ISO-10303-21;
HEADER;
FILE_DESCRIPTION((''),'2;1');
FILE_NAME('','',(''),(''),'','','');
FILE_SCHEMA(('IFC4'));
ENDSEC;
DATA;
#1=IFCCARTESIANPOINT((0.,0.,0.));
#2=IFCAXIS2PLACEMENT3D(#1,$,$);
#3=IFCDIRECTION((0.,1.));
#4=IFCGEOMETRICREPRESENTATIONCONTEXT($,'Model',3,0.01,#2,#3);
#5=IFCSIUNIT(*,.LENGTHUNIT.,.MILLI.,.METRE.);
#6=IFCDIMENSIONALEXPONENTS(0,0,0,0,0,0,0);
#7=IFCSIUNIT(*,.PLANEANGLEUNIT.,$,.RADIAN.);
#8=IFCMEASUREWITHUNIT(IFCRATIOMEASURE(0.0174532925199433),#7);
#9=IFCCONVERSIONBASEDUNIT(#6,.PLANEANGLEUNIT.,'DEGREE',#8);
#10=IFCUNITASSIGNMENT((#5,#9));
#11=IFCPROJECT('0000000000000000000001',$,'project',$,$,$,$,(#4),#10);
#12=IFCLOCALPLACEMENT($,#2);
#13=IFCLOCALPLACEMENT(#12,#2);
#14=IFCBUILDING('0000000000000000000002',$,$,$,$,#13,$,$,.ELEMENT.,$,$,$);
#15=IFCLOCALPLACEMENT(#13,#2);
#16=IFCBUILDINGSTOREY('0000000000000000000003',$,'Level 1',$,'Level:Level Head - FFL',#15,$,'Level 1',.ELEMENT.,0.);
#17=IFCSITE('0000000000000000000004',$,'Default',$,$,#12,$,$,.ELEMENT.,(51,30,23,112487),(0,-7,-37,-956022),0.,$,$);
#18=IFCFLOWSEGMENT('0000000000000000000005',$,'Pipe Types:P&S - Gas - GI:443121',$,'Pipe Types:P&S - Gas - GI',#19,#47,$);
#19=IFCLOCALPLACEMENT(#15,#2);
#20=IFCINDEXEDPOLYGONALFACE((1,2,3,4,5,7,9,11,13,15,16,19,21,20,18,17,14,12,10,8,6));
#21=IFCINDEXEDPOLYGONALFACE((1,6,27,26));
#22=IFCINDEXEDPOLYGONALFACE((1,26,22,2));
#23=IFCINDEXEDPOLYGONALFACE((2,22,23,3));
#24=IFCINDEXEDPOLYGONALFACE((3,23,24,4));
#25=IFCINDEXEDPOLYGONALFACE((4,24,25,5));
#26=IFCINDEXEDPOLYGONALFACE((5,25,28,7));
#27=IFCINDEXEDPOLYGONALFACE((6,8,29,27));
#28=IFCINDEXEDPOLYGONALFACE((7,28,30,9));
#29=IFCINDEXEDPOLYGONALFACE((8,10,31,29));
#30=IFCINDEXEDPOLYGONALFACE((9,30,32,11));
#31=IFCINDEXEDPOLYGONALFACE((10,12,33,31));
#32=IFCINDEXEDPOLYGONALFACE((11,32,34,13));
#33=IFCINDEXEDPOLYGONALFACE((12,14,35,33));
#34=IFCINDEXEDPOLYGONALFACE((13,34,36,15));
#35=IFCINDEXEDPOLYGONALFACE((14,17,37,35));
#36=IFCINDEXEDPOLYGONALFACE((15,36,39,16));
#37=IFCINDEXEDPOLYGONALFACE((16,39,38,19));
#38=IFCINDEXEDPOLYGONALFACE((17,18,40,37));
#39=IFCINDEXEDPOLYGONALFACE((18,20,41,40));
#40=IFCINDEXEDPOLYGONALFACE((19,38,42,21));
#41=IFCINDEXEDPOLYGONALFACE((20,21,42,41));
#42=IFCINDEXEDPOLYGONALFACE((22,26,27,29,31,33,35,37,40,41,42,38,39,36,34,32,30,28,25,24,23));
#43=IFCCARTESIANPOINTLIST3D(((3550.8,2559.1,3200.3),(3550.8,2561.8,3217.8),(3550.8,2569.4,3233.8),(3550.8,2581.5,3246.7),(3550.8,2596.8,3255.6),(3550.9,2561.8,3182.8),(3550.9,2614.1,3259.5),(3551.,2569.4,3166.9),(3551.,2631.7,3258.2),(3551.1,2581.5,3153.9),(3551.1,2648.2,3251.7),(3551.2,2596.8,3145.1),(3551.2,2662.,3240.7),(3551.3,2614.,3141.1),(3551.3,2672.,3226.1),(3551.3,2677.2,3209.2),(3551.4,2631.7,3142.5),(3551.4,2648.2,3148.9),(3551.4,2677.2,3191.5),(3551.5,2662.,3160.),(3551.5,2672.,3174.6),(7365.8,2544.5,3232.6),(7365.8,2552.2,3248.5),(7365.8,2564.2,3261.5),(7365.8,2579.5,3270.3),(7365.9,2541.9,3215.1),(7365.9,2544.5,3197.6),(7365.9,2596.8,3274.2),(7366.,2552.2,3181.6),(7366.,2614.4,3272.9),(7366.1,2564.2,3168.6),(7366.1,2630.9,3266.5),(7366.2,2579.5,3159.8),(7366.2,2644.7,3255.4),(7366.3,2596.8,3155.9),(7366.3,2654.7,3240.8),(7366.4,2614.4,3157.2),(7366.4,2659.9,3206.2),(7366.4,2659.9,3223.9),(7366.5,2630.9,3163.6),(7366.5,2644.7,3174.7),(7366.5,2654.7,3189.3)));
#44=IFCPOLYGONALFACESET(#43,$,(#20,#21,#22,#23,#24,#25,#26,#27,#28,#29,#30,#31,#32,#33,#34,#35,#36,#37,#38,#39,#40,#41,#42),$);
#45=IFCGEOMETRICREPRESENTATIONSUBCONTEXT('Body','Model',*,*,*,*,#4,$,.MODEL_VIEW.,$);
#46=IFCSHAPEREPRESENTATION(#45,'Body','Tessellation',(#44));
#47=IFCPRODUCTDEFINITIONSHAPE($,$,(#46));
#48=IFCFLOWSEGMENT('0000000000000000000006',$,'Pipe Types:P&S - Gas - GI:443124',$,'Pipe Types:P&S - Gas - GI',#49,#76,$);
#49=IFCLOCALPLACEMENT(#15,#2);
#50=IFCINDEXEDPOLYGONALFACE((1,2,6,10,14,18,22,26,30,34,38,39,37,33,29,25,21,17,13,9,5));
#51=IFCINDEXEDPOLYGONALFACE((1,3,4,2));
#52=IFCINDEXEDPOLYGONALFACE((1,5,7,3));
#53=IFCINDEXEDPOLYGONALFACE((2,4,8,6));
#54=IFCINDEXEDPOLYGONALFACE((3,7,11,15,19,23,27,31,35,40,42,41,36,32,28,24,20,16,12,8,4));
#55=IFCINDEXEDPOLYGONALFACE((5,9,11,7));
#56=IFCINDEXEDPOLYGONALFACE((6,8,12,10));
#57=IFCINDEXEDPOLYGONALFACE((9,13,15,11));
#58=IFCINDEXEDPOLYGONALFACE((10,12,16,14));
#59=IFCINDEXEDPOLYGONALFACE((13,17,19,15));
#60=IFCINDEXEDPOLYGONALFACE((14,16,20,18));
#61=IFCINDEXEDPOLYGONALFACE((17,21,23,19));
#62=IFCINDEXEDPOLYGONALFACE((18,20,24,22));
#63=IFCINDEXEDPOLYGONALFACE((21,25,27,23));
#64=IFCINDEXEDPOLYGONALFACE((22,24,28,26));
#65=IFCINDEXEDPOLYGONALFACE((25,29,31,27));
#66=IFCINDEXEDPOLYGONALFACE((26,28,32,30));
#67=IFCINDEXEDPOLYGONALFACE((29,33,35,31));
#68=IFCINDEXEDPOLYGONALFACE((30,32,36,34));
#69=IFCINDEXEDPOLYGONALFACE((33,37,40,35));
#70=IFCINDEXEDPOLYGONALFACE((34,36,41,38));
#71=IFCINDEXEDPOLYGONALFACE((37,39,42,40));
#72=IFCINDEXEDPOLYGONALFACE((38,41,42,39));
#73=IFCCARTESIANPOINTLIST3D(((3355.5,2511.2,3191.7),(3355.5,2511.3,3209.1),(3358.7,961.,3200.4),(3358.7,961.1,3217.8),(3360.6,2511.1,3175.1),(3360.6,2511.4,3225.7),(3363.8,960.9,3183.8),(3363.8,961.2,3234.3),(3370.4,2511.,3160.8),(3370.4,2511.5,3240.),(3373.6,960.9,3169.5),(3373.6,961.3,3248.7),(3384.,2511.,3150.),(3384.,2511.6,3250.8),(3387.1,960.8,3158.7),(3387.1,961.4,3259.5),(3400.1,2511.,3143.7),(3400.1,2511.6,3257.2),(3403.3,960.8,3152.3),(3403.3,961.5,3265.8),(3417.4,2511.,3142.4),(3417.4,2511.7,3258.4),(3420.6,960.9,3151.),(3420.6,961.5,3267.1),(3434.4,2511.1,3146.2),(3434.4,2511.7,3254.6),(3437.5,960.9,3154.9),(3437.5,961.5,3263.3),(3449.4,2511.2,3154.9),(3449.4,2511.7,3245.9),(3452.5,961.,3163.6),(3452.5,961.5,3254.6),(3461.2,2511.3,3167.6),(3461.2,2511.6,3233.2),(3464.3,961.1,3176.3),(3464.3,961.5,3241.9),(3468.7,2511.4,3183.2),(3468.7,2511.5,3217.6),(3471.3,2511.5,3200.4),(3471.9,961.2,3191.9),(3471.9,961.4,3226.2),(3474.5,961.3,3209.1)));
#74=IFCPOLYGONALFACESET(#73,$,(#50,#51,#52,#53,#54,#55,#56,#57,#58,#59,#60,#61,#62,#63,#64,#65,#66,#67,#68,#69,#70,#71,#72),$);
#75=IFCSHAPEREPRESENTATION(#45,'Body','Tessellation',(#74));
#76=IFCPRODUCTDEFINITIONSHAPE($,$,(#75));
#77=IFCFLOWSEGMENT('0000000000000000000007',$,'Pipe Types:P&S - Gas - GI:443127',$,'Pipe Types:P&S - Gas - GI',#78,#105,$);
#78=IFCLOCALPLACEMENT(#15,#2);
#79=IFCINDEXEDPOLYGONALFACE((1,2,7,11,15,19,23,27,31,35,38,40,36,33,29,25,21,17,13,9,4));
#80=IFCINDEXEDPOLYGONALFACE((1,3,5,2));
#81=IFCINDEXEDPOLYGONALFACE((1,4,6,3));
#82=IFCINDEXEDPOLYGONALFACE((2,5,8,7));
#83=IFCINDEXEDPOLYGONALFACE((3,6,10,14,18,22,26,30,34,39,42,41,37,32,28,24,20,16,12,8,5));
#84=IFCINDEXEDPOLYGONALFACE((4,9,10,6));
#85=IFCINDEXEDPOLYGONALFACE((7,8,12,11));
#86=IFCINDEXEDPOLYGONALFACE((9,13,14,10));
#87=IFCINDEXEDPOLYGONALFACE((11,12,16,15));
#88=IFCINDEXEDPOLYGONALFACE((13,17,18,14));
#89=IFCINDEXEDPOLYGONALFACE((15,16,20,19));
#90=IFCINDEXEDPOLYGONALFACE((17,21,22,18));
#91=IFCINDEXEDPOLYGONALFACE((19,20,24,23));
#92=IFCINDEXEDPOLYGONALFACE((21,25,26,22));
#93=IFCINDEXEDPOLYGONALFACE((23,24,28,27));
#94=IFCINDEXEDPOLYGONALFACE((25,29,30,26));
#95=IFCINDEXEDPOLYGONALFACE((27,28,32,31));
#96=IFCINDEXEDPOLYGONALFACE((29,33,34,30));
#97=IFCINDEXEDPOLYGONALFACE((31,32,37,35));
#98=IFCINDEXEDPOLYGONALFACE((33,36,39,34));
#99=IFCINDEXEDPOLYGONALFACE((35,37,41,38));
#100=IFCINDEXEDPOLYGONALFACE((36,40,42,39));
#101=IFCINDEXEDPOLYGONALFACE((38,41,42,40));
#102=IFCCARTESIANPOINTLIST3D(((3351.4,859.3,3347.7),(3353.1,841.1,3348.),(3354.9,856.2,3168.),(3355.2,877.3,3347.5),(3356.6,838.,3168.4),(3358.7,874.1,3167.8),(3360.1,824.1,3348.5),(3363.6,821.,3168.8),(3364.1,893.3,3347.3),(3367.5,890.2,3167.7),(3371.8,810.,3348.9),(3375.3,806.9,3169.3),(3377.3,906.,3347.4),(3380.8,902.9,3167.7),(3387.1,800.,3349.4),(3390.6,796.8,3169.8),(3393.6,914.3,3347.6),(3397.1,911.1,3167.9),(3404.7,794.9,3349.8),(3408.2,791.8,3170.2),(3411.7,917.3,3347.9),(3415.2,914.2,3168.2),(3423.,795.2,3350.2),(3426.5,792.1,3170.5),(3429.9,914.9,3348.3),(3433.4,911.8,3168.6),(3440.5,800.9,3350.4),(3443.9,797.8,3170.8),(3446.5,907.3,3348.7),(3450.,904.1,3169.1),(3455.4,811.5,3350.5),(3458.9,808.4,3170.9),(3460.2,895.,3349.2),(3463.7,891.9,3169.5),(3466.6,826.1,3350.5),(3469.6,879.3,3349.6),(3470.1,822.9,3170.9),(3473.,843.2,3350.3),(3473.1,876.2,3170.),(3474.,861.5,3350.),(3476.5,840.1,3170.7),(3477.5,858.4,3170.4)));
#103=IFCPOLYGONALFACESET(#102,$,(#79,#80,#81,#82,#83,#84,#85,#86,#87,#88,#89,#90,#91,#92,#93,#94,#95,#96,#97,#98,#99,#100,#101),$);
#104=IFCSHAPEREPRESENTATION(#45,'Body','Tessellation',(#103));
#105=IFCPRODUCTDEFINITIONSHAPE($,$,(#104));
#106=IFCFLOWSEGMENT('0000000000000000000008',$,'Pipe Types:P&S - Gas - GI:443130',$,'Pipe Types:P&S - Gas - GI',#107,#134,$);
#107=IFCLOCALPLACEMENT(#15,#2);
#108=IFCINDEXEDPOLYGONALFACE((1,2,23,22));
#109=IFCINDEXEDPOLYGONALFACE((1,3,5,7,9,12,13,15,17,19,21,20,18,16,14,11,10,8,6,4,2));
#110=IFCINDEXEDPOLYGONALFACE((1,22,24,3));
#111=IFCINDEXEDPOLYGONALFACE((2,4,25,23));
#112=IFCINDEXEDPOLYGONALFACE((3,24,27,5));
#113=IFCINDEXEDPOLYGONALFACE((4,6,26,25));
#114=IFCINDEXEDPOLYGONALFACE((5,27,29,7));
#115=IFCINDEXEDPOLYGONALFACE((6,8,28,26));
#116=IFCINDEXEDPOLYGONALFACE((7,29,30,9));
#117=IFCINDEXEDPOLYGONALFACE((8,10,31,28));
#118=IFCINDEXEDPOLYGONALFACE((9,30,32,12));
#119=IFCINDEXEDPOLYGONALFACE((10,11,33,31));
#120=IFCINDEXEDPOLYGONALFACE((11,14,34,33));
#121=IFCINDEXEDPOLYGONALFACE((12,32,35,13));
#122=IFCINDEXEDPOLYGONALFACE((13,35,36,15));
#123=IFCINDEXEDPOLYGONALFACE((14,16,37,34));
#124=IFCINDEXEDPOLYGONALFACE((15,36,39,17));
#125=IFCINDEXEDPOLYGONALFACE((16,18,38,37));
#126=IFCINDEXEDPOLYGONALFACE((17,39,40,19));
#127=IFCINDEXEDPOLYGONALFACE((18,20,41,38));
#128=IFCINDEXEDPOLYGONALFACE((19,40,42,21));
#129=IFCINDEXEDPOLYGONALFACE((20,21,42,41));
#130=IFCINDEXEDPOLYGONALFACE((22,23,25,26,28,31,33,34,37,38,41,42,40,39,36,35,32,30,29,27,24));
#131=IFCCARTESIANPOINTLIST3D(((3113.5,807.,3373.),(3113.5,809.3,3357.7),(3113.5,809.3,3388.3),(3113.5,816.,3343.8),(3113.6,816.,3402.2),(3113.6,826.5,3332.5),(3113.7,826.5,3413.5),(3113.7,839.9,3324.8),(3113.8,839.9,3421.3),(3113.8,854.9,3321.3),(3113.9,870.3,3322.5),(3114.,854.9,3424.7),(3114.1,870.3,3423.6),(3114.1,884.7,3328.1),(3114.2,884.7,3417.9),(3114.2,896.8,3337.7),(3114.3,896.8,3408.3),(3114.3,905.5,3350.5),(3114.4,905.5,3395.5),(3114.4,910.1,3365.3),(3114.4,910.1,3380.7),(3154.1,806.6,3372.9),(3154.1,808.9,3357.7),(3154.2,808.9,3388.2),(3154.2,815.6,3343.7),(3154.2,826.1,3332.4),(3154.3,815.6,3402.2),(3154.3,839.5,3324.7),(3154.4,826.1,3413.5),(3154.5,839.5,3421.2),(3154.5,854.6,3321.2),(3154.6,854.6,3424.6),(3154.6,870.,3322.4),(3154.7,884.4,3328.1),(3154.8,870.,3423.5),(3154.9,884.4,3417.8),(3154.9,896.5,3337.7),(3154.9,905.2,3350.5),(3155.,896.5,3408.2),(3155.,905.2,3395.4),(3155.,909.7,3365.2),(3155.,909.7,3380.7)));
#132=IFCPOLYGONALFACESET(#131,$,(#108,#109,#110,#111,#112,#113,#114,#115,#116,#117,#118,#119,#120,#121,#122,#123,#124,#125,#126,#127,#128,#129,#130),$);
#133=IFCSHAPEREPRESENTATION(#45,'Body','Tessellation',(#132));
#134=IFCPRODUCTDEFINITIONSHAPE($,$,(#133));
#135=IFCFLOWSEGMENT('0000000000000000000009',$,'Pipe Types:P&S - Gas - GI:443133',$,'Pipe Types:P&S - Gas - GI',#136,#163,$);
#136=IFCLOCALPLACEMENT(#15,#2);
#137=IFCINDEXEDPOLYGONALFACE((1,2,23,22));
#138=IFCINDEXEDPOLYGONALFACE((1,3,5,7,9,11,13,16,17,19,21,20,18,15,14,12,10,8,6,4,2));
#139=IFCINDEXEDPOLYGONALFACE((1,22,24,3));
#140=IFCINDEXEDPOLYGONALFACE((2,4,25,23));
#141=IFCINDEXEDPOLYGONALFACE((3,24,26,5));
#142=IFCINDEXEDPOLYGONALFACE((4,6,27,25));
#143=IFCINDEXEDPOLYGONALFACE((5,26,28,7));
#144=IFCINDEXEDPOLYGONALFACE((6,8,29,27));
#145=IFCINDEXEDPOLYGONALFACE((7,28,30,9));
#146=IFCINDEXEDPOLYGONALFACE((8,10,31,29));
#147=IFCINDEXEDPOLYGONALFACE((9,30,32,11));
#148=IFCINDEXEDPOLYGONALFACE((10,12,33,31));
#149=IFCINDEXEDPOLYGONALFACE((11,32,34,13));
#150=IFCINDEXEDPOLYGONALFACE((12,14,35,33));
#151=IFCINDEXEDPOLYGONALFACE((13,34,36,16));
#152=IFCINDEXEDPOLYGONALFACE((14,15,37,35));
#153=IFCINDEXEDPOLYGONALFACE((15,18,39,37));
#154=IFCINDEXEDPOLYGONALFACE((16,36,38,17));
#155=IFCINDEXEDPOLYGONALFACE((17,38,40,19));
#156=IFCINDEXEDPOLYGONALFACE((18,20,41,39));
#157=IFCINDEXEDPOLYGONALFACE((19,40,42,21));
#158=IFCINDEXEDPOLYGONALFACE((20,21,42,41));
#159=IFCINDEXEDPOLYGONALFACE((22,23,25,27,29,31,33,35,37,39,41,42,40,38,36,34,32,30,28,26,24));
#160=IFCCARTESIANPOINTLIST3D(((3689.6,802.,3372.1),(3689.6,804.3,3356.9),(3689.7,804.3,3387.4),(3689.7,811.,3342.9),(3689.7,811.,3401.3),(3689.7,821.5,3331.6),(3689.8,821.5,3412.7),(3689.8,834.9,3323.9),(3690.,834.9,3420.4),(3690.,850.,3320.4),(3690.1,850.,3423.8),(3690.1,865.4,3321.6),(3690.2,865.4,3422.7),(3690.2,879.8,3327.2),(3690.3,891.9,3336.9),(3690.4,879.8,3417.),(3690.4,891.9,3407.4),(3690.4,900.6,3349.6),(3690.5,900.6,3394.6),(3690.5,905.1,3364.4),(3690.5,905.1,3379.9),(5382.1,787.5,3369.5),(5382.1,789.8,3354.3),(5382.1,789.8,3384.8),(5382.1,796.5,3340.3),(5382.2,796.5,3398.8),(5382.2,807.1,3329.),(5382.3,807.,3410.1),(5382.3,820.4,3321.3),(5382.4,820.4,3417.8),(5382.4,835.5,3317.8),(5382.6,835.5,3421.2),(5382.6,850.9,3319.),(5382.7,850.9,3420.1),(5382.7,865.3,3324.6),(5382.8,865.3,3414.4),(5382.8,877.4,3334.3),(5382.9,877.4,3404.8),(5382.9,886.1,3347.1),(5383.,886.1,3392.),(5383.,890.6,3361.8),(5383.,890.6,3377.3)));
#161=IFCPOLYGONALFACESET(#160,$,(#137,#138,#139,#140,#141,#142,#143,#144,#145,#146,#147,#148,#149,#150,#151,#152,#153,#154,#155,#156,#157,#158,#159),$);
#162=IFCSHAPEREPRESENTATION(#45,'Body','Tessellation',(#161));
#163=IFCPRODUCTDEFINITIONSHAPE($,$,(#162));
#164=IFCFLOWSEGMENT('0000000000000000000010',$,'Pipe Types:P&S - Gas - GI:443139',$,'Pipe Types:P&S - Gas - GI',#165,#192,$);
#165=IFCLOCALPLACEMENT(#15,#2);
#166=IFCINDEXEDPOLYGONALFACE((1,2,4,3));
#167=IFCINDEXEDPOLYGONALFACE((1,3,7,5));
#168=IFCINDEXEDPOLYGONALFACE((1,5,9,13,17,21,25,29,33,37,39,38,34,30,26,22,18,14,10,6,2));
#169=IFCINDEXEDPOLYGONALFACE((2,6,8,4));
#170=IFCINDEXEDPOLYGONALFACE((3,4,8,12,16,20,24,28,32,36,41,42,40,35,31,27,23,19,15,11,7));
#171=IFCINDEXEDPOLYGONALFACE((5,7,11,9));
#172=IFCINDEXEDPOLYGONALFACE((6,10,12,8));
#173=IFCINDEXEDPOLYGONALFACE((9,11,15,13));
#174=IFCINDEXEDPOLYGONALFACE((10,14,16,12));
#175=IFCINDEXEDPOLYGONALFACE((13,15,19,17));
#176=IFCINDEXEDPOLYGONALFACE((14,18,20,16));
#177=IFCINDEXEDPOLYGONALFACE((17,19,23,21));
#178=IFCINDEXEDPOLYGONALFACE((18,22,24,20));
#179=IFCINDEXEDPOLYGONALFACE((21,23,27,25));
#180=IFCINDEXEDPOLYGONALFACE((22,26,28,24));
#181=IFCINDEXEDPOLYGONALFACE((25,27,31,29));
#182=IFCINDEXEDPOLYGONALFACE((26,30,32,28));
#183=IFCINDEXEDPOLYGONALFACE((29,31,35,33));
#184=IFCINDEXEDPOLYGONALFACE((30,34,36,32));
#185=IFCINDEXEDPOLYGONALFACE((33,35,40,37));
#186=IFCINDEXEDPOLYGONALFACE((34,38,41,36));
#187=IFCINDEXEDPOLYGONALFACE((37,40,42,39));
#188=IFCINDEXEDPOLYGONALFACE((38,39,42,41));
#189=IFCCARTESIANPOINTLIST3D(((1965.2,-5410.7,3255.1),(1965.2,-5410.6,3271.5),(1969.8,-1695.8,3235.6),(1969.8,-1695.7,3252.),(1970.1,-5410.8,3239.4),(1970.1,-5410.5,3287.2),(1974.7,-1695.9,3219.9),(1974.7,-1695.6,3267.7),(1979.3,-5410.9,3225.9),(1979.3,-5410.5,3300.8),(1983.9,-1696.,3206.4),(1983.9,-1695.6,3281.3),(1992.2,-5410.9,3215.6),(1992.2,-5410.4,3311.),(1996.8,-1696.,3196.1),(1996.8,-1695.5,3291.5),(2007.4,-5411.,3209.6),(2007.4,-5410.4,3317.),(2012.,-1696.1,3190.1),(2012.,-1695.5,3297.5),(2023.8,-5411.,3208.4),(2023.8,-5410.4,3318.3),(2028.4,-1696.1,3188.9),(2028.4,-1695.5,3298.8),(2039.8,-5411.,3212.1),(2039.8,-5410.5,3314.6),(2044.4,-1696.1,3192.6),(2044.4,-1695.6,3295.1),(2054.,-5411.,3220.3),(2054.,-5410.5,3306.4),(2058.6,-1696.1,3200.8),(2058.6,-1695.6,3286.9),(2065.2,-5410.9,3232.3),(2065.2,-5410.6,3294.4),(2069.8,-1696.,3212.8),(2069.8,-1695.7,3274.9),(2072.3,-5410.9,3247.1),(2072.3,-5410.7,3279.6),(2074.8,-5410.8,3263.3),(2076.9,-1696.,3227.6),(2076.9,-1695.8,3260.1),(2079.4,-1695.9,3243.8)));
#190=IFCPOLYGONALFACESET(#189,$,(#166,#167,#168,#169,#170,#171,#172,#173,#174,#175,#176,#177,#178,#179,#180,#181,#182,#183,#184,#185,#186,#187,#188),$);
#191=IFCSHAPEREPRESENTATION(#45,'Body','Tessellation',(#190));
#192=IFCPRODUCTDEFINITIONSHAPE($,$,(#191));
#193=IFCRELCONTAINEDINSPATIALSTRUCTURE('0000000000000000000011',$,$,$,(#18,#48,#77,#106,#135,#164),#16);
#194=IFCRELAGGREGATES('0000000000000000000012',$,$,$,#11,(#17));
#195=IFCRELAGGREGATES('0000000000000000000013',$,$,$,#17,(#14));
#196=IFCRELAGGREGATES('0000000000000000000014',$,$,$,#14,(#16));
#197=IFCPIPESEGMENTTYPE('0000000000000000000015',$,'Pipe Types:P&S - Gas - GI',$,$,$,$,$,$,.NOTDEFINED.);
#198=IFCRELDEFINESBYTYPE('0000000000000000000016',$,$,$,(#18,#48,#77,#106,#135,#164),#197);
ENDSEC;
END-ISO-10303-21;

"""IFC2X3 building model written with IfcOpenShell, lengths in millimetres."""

from ifc_helpers import new_model, entity, si_unit, converted_unit, direction, frame, frame_2d, origin, origin_2d_with_axis, place, context, subcontext, project, spatial, circle, extrude, type_object, element, save


model = new_model("IFC2X3")

# Units and contexts
model_context = context("Model", 3, precision=0.01, world=origin(), true_north=direction((0.0, 1.0)))
body_context = subcontext(model_context, "Body", "Model", "MODEL_VIEW")
ifc_project = project(units=[si_unit("LENGTHUNIT", "METRE", prefix="MILLI"), converted_unit("PLANEANGLEUNIT", "DEGREE", entity("IfcRatioMeasure", 0.0174532925199433), si_unit("PLANEANGLEUNIT", "RADIAN"), dimensions=[0, 0, 0, 0, 0, 0, 0])], contexts=[model_context])

# Site, building, storey
site_placement = place(None, origin())
site = spatial("IfcSite", under=ifc_project, at=site_placement, Name="Default", CompositionType="ELEMENT", RefLatitude=(51, 30, 23, 112487), RefLongitude=(0, -7, -37, -956022), RefElevation=0.0)
building_placement = place(site_placement, origin())
building = spatial("IfcBuilding", under=site, at=building_placement, CompositionType="ELEMENT")
storey_placement = place(building_placement, origin())
storey = spatial("IfcBuildingStorey", under=building, at=storey_placement, Name="Level 1", ObjectType="Level:Level Head - FFL", LongName="Level 1", CompositionType="ELEMENT", Elevation=0.0)

# Flow segments
pipe_segment_type = type_object("IfcPipeSegmentType", Name="Pipe Types:P&S - Gas - GI", PredefinedType="NOTDEFINED")
flow_segment_1_placement = place(storey_placement, origin())
element("IfcFlowSegment", 1, at=flow_segment_1_placement, inside=storey, type_object=pipe_segment_type, Name="Pipe Types:P&S - Gas - GI:443121", ObjectType="Pipe Types:P&S - Gas - GI", context=body_context, shape_type="SweptSolid", body=[
    extrude(circle(Radius=59.4, at=origin_2d_with_axis()), frame((7366.1, 2601.2, 3215.1), z_axis=(-0.999982, 0.004522, -0.003859), x_axis=(-0.004522, -0.99999, 0.0)), (0.0, 0.0, 1.0), 3815.1),
])
flow_segment_2_placement = place(storey_placement, origin())
element("IfcFlowSegment", 2, at=flow_segment_2_placement, inside=storey, type_object=pipe_segment_type, Name="Pipe Types:P&S - Gas - GI:443124", ObjectType="Pipe Types:P&S - Gas - GI", context=body_context, shape_type="SweptSolid", body=[
    extrude(circle(Radius=58.2, at=origin_2d_with_axis()), frame((3413.1, 2511.3, 3200.4), z_axis=(0.002039, -0.999982, 0.005605), x_axis=(0.999998, 0.002039, 0.0)), (0.0, 0.0, 1.0), 1550.2),
])
flow_segment_3_placement = place(storey_placement, origin())
element("IfcFlowSegment", 3, at=flow_segment_3_placement, inside=storey, type_object=pipe_segment_type, Name="Pipe Types:P&S - Gas - GI:443127", ObjectType="Pipe Types:P&S - Gas - GI", context=body_context, shape_type="SweptSolid", body=[
    extrude(circle(Radius=61.5, at=frame_2d((0.0, 0.0), x_axis=(1.0, 0.0))), frame((3416.3, 852.7, 3169.3), z_axis=(-0.019398, 0.017366, 0.999661), x_axis=(-0.667013, -0.745046, 0.0)), (0.0, 0.0, 1.0), 179.7),
])
flow_segment_4_placement = place(storey_placement, origin())
element("IfcFlowSegment", 4, at=flow_segment_4_placement, inside=storey, type_object=pipe_segment_type, Name="Pipe Types:P&S - Gas - GI:443130", ObjectType="Pipe Types:P&S - Gas - GI", context=body_context, shape_type="SweptSolid", body=[
    extrude(circle(Radius=51.8, at=origin_2d_with_axis()), frame((3154.6, 858.5, 3372.9), z_axis=(-0.999962, 0.008564, 0.001526), x_axis=(-0.008564, -0.999963, 0.0)), (0.0, 0.0, 1.0), 40.7),
])
flow_segment_5_placement = place(storey_placement, origin())
element("IfcFlowSegment", 5, at=flow_segment_5_placement, inside=storey, type_object=pipe_segment_type, Name="Pipe Types:P&S - Gas - GI:443133", ObjectType="Pipe Types:P&S - Gas - GI", context=body_context, shape_type="SweptSolid", body=[
    extrude(circle(Radius=51.8, at=frame_2d((0.0, 0.0), x_axis=(1.0, 0.0))), frame((5382.5, 839.4, 3369.5), z_axis=(-0.999962, 0.008564, 0.001526), x_axis=(-0.008564, -0.999963, 0.0)), (0.0, 0.0, 1.0), 1692.5),
])
flow_segment_6_placement = place(storey_placement, origin())
element("IfcFlowSegment", 6, at=flow_segment_6_placement, inside=storey, type_object=pipe_segment_type, Name="Pipe Types:P&S - Gas - GI:443139", ObjectType="Pipe Types:P&S - Gas - GI", context=body_context, shape_type="SweptSolid", body=[
    extrude(circle(Radius=55.1, at=frame_2d((0.0, 0.0), x_axis=(1.0, 0.0))), frame((2019.7, -5410.7, 3263.3), z_axis=(0.001239, 0.999985, -0.005248), x_axis=(0.999999, -0.001239, 0.0)), (0.0, 0.0, 1.0), 3715.0),
])

save(model, "model.ifc")
